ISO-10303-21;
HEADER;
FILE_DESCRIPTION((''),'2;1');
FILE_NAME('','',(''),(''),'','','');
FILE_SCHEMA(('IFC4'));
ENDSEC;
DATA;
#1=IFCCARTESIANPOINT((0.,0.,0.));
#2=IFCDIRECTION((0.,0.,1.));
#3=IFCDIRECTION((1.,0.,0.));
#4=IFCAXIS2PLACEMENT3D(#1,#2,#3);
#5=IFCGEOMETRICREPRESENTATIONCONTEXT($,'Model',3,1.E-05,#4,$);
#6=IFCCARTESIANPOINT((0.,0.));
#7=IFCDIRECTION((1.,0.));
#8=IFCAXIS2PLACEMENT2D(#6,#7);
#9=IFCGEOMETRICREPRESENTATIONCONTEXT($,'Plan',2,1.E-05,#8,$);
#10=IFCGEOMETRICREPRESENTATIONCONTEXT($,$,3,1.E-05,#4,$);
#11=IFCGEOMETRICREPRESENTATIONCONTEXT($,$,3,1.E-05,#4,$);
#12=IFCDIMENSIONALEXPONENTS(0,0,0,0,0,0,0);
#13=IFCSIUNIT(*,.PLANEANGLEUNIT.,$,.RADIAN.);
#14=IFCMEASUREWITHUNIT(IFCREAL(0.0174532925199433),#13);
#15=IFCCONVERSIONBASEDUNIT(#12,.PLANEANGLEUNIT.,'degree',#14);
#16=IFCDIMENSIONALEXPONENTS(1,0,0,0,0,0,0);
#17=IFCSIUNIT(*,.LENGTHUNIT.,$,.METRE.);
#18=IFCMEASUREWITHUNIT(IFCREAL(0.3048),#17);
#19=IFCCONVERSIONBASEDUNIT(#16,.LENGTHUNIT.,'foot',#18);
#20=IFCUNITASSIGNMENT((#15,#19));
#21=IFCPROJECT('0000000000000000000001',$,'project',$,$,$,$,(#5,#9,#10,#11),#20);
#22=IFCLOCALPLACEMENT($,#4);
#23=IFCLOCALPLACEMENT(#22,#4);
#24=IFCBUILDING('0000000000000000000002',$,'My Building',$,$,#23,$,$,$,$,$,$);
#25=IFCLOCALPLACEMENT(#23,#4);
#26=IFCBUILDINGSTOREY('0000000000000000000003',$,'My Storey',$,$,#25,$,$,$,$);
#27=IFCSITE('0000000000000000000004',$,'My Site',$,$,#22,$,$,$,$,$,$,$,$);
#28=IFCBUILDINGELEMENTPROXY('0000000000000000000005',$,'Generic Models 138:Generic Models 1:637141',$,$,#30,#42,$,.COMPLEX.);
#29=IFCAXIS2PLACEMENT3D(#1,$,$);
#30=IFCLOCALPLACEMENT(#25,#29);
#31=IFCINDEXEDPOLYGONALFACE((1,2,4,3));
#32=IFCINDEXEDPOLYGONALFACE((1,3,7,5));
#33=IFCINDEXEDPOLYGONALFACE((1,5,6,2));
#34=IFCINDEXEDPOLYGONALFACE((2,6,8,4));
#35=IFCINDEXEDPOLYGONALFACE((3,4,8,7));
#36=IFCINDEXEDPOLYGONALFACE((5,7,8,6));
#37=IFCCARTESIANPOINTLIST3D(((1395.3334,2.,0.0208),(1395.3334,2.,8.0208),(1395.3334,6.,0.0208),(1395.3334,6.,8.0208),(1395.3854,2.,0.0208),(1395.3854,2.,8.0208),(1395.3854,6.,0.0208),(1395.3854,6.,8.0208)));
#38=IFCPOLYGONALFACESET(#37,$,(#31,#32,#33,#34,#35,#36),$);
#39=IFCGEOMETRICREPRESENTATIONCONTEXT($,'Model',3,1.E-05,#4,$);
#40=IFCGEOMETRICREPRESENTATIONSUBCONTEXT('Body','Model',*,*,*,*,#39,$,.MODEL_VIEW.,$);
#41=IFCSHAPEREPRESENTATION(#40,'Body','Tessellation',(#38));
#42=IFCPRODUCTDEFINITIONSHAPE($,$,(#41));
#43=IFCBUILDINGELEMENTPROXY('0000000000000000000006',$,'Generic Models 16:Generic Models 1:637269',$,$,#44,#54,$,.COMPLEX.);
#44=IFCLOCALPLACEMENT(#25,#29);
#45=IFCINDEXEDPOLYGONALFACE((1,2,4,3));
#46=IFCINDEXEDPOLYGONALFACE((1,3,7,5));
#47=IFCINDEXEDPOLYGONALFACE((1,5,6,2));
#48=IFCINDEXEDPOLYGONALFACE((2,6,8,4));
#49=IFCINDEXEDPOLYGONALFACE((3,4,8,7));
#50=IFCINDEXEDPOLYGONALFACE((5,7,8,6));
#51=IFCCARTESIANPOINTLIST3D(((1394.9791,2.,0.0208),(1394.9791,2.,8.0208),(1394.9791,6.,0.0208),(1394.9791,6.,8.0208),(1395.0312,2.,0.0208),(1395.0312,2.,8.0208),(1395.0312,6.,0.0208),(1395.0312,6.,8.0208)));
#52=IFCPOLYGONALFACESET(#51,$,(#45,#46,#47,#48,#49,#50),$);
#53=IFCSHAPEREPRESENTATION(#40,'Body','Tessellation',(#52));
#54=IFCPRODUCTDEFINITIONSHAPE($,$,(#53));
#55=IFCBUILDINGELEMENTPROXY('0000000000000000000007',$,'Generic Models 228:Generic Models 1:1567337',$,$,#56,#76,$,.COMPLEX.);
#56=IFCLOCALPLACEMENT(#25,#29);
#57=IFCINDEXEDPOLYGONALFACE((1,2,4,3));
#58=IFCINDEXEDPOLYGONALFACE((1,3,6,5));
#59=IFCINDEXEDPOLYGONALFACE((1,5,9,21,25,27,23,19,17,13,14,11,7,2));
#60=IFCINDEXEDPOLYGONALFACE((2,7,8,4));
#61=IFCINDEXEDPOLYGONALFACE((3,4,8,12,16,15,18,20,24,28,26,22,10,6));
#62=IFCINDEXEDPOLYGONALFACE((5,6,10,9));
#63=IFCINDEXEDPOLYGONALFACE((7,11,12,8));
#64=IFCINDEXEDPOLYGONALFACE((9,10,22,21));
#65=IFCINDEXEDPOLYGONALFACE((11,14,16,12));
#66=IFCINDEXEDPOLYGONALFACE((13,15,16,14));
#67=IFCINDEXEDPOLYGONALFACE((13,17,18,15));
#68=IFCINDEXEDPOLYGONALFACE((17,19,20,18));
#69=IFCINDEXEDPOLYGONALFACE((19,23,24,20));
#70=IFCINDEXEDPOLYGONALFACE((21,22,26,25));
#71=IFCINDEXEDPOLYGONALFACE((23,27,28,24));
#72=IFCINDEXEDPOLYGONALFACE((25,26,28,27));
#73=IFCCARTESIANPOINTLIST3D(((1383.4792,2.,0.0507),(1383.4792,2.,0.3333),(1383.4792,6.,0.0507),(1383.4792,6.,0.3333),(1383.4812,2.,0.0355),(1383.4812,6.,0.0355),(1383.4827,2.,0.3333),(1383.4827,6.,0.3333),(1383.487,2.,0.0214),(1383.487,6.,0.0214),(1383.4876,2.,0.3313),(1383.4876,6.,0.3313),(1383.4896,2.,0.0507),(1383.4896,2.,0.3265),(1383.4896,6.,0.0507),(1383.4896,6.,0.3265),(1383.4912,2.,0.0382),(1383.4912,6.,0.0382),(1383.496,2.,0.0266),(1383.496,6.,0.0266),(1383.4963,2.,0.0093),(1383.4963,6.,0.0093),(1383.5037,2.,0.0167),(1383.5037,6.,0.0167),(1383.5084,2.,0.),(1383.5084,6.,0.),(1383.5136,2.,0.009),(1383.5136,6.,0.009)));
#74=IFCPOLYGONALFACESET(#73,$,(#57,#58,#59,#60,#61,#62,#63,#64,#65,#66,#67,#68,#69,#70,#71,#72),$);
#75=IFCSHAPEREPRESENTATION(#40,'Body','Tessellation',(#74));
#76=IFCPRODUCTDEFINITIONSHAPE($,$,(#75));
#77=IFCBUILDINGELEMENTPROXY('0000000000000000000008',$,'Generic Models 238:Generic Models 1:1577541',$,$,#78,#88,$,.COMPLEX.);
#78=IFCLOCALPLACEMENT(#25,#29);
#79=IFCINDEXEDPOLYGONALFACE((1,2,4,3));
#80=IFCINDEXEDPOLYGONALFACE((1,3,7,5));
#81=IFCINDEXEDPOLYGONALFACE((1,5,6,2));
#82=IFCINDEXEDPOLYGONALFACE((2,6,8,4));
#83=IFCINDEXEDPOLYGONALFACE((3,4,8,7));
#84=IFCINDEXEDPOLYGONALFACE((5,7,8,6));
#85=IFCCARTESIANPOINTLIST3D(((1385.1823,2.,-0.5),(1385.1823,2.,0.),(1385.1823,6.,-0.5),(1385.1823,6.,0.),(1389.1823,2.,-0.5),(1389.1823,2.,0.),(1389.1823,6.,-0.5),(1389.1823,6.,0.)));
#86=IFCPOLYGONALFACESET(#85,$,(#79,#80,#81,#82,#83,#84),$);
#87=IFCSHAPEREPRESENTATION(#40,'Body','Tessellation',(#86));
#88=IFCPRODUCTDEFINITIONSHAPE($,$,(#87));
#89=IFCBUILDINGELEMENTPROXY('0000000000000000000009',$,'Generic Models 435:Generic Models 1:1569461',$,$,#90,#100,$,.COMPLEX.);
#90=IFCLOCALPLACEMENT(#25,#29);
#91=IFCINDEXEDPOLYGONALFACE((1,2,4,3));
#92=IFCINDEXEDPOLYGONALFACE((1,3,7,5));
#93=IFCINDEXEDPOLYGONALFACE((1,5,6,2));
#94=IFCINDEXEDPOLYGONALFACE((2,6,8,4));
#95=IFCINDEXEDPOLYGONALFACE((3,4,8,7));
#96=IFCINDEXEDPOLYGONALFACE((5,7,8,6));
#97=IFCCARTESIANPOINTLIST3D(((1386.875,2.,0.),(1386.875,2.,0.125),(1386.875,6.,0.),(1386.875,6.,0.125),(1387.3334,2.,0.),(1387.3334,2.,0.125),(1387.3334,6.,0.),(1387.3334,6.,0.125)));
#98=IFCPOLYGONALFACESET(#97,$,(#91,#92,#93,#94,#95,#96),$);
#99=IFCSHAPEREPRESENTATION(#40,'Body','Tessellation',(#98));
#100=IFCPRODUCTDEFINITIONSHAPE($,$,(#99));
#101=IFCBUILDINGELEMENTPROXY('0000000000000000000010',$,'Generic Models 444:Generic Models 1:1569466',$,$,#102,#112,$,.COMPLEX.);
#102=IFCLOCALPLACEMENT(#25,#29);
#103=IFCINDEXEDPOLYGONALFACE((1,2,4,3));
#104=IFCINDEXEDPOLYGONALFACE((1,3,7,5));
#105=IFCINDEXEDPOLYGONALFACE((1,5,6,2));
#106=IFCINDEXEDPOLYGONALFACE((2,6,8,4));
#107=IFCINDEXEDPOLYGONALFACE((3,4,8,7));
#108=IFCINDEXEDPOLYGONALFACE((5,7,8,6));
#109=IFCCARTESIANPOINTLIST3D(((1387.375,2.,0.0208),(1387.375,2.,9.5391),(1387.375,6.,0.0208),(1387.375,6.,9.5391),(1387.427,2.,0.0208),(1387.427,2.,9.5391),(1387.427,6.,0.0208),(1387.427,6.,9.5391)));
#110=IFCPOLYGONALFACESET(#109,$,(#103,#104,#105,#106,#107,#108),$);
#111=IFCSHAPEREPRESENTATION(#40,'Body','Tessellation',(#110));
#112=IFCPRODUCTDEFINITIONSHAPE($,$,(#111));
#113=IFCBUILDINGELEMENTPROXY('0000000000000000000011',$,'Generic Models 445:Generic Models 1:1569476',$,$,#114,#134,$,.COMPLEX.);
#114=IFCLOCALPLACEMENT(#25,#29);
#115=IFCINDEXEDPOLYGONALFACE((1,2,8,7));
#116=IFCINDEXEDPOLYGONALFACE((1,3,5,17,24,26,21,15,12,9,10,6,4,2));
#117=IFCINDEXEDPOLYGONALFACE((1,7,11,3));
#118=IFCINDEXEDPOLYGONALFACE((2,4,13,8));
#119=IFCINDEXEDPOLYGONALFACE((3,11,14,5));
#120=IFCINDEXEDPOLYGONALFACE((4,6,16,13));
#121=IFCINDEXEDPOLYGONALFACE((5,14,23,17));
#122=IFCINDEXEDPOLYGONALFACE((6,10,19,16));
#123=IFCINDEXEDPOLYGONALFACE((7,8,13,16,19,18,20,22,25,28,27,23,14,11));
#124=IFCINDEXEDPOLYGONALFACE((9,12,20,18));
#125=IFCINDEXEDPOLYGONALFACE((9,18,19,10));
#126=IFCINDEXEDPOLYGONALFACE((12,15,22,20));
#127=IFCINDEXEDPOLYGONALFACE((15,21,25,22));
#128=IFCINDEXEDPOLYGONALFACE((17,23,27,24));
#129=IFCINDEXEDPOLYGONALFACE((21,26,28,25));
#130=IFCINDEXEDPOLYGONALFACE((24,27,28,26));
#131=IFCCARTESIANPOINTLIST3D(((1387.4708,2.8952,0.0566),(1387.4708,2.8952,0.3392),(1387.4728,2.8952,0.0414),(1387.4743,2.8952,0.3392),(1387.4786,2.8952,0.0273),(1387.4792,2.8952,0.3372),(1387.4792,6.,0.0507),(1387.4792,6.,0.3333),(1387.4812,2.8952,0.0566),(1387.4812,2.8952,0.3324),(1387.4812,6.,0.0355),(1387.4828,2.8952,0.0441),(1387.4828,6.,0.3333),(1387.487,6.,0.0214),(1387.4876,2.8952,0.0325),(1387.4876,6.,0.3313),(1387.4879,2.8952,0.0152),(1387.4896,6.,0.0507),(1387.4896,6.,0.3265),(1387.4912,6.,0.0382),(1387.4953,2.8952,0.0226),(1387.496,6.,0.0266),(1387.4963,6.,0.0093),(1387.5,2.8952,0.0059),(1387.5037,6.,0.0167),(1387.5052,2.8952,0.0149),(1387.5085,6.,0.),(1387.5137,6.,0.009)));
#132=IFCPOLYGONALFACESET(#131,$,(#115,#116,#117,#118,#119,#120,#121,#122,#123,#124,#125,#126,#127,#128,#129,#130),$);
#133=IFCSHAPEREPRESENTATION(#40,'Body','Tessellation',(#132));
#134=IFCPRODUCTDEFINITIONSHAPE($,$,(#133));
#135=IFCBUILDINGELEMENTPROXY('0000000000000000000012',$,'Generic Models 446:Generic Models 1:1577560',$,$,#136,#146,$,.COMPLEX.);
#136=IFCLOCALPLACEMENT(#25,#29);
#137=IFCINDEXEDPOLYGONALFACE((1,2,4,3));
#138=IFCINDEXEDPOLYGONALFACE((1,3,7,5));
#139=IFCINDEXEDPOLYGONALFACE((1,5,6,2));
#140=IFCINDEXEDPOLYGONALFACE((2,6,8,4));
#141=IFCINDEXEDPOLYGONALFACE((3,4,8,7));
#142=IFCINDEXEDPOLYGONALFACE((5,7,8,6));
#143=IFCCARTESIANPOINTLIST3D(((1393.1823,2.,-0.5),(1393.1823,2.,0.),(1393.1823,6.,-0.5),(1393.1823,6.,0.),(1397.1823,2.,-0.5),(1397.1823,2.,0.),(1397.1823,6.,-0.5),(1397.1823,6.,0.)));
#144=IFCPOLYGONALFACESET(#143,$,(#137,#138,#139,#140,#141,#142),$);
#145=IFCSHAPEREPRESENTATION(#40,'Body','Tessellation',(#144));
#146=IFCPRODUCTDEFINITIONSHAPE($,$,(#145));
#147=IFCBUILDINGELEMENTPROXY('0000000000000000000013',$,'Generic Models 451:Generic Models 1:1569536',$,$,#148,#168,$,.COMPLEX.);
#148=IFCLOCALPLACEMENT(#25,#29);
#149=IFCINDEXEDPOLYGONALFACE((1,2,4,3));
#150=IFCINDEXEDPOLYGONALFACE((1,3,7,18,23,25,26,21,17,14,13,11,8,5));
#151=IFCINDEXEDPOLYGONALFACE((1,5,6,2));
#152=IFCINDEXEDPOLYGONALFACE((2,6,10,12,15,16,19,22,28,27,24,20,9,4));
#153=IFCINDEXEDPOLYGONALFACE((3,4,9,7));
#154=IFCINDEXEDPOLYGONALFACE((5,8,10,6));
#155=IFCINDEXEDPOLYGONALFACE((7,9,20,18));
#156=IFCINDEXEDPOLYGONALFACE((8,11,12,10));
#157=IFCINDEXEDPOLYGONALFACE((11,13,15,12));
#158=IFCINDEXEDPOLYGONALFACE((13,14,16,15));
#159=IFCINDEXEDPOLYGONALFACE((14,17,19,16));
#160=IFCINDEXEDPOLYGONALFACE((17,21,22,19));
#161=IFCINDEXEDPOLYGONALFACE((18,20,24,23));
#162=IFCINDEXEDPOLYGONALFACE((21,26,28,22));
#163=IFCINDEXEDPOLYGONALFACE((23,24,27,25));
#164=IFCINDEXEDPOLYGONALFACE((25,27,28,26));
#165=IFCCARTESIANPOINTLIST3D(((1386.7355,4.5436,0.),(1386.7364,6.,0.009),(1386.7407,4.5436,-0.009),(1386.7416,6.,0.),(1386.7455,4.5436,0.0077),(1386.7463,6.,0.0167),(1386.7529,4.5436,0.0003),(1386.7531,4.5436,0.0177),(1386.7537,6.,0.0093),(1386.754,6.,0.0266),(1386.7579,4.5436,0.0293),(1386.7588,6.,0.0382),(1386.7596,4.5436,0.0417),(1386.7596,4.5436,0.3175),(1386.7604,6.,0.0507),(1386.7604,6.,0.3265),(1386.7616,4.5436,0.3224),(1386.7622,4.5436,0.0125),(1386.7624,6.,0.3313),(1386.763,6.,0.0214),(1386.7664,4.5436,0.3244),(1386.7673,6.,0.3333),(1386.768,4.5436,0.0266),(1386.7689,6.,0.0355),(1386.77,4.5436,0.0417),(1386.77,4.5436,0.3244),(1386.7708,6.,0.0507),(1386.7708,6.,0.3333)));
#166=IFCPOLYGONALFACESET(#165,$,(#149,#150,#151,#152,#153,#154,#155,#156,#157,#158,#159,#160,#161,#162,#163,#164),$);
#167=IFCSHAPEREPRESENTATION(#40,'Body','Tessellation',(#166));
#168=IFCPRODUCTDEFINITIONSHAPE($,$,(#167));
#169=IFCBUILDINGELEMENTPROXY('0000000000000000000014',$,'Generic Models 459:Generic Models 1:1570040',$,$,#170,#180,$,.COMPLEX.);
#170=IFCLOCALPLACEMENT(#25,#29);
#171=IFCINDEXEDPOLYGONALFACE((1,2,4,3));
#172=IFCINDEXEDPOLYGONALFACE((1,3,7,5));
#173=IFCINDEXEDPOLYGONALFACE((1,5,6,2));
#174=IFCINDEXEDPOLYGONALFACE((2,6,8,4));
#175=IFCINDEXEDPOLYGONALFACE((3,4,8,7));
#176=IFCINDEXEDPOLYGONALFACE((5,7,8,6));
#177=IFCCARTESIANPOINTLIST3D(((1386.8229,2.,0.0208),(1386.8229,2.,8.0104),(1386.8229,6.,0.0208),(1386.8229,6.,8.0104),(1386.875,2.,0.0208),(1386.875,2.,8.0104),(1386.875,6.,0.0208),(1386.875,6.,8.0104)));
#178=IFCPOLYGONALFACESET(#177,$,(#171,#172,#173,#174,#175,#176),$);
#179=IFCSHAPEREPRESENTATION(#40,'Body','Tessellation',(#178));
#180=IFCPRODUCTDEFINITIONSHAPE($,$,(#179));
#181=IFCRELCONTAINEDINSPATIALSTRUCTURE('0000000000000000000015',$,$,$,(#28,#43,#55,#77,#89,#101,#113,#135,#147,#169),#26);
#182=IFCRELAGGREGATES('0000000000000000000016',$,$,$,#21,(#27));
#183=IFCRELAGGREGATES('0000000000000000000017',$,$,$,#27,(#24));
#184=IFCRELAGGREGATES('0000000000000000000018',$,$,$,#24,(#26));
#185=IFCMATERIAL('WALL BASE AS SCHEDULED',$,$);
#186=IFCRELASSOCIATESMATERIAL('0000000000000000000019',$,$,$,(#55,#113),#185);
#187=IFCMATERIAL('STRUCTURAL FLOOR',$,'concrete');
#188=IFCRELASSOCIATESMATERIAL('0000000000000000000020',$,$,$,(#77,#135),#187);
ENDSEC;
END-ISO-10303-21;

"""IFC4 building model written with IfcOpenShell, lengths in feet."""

from ifc_helpers import new_model, entity, si_unit, converted_unit, frame, origin_with_axes, origin_2d_with_axis, place, context, subcontext, project, spatial, polyline, line, indexed_curve, outline, extrude, material, element, save


model = new_model("IFC4")

# Units and contexts
model_context_1 = context("Model", 3, precision=1e-05, world=origin_with_axes())
plan_context = context("Plan", 2, precision=1e-05, world=origin_2d_with_axis())
model_context_2 = context("Model", 3, precision=1e-05, world=origin_with_axes())
context_of_model_1 = context(None, 3, precision=1e-05, world=origin_with_axes())
context_of_model_2 = context(None, 3, precision=1e-05, world=origin_with_axes())
body_context = subcontext(model_context_2, "Body", "Model", "MODEL_VIEW")
ifc_project = project(units=[converted_unit("PLANEANGLEUNIT", "degree", entity("IfcReal", 0.0174532925199433), si_unit("PLANEANGLEUNIT", "RADIAN"), dimensions=[0, 0, 0, 0, 0, 0, 0]), converted_unit("LENGTHUNIT", "foot", entity("IfcReal", 0.3048), si_unit("LENGTHUNIT", "METRE"), dimensions=[1, 0, 0, 0, 0, 0, 0])], contexts=[model_context_1, plan_context, context_of_model_1, context_of_model_2])

# Site, building, storey
site_placement = place(None, origin_with_axes())
site = spatial("IfcSite", under=ifc_project, at=site_placement, Name="My Site")
building_placement = place(site_placement, origin_with_axes())
building = spatial("IfcBuilding", under=site, at=building_placement, Name="My Building")
storey_placement = place(building_placement, origin_with_axes())
storey = spatial("IfcBuildingStorey", under=building, at=storey_placement, Name="My Storey")

# Building element proxies
proxy_1_placement = place(storey_placement, frame((1395.3334, 6.0, 0.0208), z_axis=(0.0, -1.0, 0.0), x_axis=(0.0, 0.0, 1.0)))
element("IfcBuildingElementProxy", 1, at=proxy_1_placement, inside=storey, Name="Generic Models 138:Generic Models 1:637141", PredefinedType="COMPLEX", context=body_context, shape_type="SweptSolid", body=[
    extrude(outline(indexed_curve([(-0.026, -4.0), (0.026, -4.0), (0.026, 4.0), (-0.026, 4.0)], segments=[line(4, 1), line(1, 2), line(2, 3), line(3, 4)], self_intersect=False)), frame((4.0, -0.026, 0.0), z_axis=(0.0, 0.0, -1.0), x_axis=(0.0, 1.0, 0.0)), (0.0, 0.0, -1.0), 4.0),
])
proxy_2_placement = place(storey_placement, frame((1394.9791, 6.0, 0.0208), z_axis=(0.0, -1.0, 0.0), x_axis=(0.0, 0.0, 1.0)))
element("IfcBuildingElementProxy", 2, at=proxy_2_placement, inside=storey, Name="Generic Models 16:Generic Models 1:637269", PredefinedType="COMPLEX", context=body_context, shape_type="SweptSolid", body=[
    extrude(outline(polyline([(-0.026, -4.0), (0.026, -4.0), (0.026, 4.0), (-0.026, 4.0), (-0.026, -4.0)])), frame((4.0, -0.026, 0.0), z_axis=(0.0, 0.0, -1.0), x_axis=(0.0, 1.0, 0.0)), (0.0, 0.0, -1.0), 4.0),
])
ifc_material_1 = material(Name="WALL BASE AS SCHEDULED")
proxy_3_placement = place(storey_placement, frame((1383.4792, 6.0, 0.0), z_axis=(0.0, -1.0, 0.0), x_axis=(0.0, 0.0, 1.0)))
element("IfcBuildingElementProxy", 3, at=proxy_3_placement, inside=storey, material=ifc_material_1, Name="Generic Models 228:Generic Models 1:1567337", PredefinedType="COMPLEX", context=body_context, shape_type="SweptSolid", body=[
    extrude(outline(polyline([(0.2206, 0.0), (0.2204, 0.0036), (0.2182, 0.0083), (0.2132, 0.01), (-0.0621, -0.0058), (-0.0747, -0.0049), (-0.0865, -0.0007), (-0.0969, 0.0063), (-0.1051, 0.0158), (-0.1138, 0.0101), (-0.1038, -0.0014), (-0.0912, -0.01), (-0.0768, -0.0151), (-0.0615, -0.0162), (0.2206, 0.0)])), frame((0.113, -0.0126, 0.0), z_axis=(0.0, 0.0, -1.0), x_axis=(0.998358, 0.057286, 0.0)), (0.0, 0.0, -1.0), 4.0),
])
ifc_material_2 = material(Name="STRUCTURAL FLOOR", Category="concrete")
proxy_4_placement = place(storey_placement, frame((1385.1823, 6.0, -0.5), z_axis=(0.0, -1.0, 0.0), x_axis=(0.0, 0.0, 1.0)))
element("IfcBuildingElementProxy", 4, at=proxy_4_placement, inside=storey, material=ifc_material_2, Name="Generic Models 238:Generic Models 1:1577541", PredefinedType="COMPLEX", context=body_context, shape_type="SweptSolid", body=[
    extrude(outline(polyline([(-0.25, -2.0), (0.25, -2.0), (0.25, 2.0), (-0.25, 2.0), (-0.25, -2.0)])), frame((0.25, -2.0, 0.0), z_axis=(0.0, 0.0, -1.0), x_axis=(1.0, 0.0, 0.0)), (0.0, 0.0, -1.0), 4.0),
])
proxy_5_placement = place(storey_placement, frame((1386.875, 6.0, 0.0), z_axis=(0.0, -1.0, 0.0), x_axis=(0.0, 0.0, 1.0)))
element("IfcBuildingElementProxy", 5, at=proxy_5_placement, inside=storey, Name="Generic Models 435:Generic Models 1:1569461", PredefinedType="COMPLEX", context=body_context, shape_type="SweptSolid", body=[
    extrude(outline(polyline([(-0.2292, -0.0625), (0.2292, -0.0625), (0.2292, 0.0625), (-0.2292, 0.0625), (-0.2292, -0.0625)])), frame((0.0625, -0.2292, 0.0), z_axis=(0.0, 0.0, -1.0), x_axis=(0.0, 1.0, 0.0)), (0.0, 0.0, -1.0), 4.0),
])
proxy_6_placement = place(storey_placement, frame((1387.375, 6.0, 0.0208), z_axis=(0.0, -1.0, 0.0), x_axis=(0.0, 0.0, 1.0)))
element("IfcBuildingElementProxy", 6, at=proxy_6_placement, inside=storey, Name="Generic Models 444:Generic Models 1:1569466", PredefinedType="COMPLEX", context=body_context, shape_type="SweptSolid", body=[
    extrude(outline(polyline([(-4.7591, -0.026), (4.7591, -0.026), (4.7591, 0.026), (-4.7591, 0.026), (-4.7591, -0.026)])), frame((4.7591, -0.026, 0.0), z_axis=(0.0, 0.0, -1.0), x_axis=(1.0, 0.0, 0.0)), (0.0, 0.0, -1.0), 4.0),
])
proxy_7_placement = place(storey_placement, frame((1387.4792, 6.0, 0.0), z_axis=(0.0, -1.0, 0.0), x_axis=(0.0, 0.0, 1.0)))
element("IfcBuildingElementProxy", 7, at=proxy_7_placement, inside=storey, material=ifc_material_1, Name="Generic Models 445:Generic Models 1:1569476", PredefinedType="COMPLEX", context=body_context, shape_type="SweptSolid", body=[
    extrude(outline(polyline([(0.2206, 0.0), (0.2204, 0.0036), (0.2182, 0.0083), (0.2132, 0.01), (-0.0621, -0.0058), (-0.0747, -0.0049), (-0.0865, -0.0007), (-0.0969, 0.0063), (-0.1051, 0.0158), (-0.1138, 0.0101), (-0.1038, -0.0014), (-0.0912, -0.01), (-0.0768, -0.0151), (-0.0615, -0.0162), (0.2206, 0.0)])), frame((0.113, -0.0126, 0.0), z_axis=(0.0, 0.0, -1.0), x_axis=(0.998358, 0.057286, 0.0)), (0.002054, -0.002598, -0.999995), 3.1048),
])
proxy_8_placement = place(storey_placement, frame((1393.1823, 6.0, -0.5), z_axis=(0.0, -1.0, 0.0), x_axis=(0.0, 0.0, 1.0)))
element("IfcBuildingElementProxy", 8, at=proxy_8_placement, inside=storey, material=ifc_material_2, Name="Generic Models 446:Generic Models 1:1577560", PredefinedType="COMPLEX", context=body_context, shape_type="SweptSolid", body=[
    extrude(outline(polyline([(-2.0, -0.25), (2.0, -0.25), (2.0, 0.25), (-2.0, 0.25), (-2.0, -0.25)])), frame((0.25, -2.0, 0.0), z_axis=(0.0, 0.0, -1.0), x_axis=(0.0, 1.0, 0.0)), (0.0, 0.0, -1.0), 4.0),
])
proxy_9_placement = place(storey_placement, frame((1386.7364, 6.0, 0.0), z_axis=(0.0, -1.0, 0.0), x_axis=(0.0, 0.0, 1.0)))
element("IfcBuildingElementProxy", 9, at=proxy_9_placement, inside=storey, Name="Generic Models 451:Generic Models 1:1569536", PredefinedType="COMPLEX", context=body_context, shape_type="SweptSolid", body=[
    extrude(outline(polyline([(0.0748, 0.0), (0.0624, -0.0017), (-0.2134, -0.0039), (-0.2182, -0.0059), (-0.2202, -0.0108), (-0.2202, -0.0144), (0.0625, -0.0122), (0.0776, -0.01), (0.0917, -0.0041), (0.1037, 0.0053), (0.1129, 0.0175), (0.1039, 0.0226), (0.0963, 0.0126), (0.0864, 0.0049), (0.0748, 0.0)])), frame((0.113, -0.0218, 0.0), z_axis=(0.0, 0.0, -1.0), x_axis=(-0.99997, -0.007803, 0.0)), (0.006156, 0.000628, -0.999981), 1.4564),
])
proxy_10_placement = place(storey_placement, frame((1386.8229, 6.0, 0.0208), z_axis=(0.0, -1.0, 0.0), x_axis=(0.0, 0.0, 1.0)))
element("IfcBuildingElementProxy", 10, at=proxy_10_placement, inside=storey, Name="Generic Models 459:Generic Models 1:1570040", PredefinedType="COMPLEX", context=body_context, shape_type="SweptSolid", body=[
    extrude(outline(polyline([(-3.9948, -0.026), (3.9948, -0.026), (3.9948, 0.026), (-3.9948, 0.026), (-3.9948, -0.026)])), frame((3.9948, -0.026, 0.0), z_axis=(0.0, 0.0, -1.0), x_axis=(-1.0, 0.0, 0.0)), (0.0, 0.0, -1.0), 4.0),
])

save(model, "model.ifc")
